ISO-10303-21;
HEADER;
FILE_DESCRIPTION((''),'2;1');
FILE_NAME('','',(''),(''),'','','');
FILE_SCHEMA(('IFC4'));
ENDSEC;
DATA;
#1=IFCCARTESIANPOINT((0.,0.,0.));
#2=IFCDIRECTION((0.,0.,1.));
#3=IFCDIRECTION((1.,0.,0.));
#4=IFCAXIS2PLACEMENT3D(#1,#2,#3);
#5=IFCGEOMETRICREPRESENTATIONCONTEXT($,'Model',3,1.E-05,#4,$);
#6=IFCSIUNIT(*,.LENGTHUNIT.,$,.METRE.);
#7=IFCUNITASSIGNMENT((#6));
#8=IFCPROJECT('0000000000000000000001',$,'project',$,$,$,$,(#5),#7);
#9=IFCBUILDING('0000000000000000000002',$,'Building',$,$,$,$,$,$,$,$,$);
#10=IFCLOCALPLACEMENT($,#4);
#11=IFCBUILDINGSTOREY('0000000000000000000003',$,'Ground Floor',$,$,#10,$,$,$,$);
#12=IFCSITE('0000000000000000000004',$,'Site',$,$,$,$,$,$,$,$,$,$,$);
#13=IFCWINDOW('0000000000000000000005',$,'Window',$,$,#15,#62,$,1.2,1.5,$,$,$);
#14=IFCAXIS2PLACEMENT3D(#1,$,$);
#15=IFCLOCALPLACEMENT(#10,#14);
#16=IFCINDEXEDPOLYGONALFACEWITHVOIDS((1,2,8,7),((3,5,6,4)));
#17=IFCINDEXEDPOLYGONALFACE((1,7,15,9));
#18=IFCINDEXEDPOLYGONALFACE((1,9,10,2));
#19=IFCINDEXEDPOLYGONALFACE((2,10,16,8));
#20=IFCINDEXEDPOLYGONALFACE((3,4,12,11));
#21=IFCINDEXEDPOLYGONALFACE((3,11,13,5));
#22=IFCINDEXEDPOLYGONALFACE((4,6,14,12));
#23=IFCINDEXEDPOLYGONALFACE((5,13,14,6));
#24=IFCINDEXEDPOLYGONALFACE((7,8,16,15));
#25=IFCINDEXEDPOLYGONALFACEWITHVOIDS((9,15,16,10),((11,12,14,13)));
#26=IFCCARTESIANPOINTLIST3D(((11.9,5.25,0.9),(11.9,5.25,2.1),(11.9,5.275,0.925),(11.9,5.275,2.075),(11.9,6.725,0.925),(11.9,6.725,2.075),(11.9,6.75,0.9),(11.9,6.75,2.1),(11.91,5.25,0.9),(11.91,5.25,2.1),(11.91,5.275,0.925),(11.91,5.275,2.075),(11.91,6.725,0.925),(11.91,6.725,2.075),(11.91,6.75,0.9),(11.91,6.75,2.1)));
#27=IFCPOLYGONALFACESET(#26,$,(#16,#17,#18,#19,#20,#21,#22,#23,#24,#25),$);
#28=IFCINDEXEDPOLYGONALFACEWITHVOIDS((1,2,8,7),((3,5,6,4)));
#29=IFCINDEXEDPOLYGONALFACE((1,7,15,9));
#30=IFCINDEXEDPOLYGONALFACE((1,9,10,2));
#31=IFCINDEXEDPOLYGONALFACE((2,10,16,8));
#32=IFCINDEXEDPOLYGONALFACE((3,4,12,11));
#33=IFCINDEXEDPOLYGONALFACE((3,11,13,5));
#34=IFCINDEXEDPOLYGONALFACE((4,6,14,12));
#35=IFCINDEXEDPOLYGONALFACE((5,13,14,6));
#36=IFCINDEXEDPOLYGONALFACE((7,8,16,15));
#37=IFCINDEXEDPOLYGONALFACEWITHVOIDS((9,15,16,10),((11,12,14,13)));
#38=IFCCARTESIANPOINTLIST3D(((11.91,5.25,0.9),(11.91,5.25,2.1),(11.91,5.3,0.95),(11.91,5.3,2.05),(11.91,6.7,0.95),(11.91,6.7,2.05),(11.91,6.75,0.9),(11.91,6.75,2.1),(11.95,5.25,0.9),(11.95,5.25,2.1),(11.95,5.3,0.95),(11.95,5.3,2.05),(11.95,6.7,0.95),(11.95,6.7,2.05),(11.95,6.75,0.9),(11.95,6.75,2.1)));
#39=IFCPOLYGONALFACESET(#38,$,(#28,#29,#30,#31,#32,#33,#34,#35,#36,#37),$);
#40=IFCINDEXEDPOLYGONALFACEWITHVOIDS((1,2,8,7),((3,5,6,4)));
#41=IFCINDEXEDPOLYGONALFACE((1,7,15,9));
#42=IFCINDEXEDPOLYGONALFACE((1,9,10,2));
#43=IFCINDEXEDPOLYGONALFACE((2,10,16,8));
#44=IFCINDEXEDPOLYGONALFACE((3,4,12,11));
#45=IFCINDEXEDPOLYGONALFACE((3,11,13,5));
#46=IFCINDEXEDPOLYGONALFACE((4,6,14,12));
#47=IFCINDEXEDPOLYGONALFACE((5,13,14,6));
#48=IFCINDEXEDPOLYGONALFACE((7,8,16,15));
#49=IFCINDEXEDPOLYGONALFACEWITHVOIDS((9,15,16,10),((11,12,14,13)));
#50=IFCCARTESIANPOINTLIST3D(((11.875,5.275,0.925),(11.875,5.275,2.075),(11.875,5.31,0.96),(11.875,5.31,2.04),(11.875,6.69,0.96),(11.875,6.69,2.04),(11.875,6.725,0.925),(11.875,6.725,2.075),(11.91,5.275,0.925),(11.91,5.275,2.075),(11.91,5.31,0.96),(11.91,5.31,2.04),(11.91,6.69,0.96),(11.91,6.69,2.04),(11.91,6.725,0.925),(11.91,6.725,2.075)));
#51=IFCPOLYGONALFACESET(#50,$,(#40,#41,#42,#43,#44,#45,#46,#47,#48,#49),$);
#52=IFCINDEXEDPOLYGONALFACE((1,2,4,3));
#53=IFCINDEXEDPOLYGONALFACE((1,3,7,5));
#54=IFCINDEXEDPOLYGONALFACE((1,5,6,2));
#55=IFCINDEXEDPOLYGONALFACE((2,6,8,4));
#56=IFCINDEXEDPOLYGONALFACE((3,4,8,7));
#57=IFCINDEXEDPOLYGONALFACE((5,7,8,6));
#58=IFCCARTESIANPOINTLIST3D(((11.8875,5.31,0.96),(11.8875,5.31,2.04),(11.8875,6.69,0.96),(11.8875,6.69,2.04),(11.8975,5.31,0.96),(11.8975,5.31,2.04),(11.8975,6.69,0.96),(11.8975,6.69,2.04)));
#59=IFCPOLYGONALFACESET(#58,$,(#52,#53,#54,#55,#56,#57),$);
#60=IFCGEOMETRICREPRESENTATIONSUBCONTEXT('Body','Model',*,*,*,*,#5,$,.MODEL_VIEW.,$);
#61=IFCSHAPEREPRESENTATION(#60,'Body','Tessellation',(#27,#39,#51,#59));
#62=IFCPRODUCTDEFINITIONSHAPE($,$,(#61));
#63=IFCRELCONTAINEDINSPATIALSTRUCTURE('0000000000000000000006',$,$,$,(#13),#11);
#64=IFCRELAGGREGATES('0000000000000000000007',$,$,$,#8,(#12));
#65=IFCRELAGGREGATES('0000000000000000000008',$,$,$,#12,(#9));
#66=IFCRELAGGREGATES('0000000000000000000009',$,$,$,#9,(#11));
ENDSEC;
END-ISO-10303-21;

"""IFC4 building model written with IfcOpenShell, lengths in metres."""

from ifc_helpers import new_model, si_unit, frame, origin_with_axes, place, context, subcontext, project, spatial, line, indexed_curve, outline, extrude, element, save


model = new_model("IFC4")

# Units and contexts
model_context = context("Model", 3, precision=1e-05, world=origin_with_axes())
body_context = subcontext(model_context, "Body", "Model", "MODEL_VIEW")
ifc_project = project(units=[si_unit("LENGTHUNIT", "METRE")], contexts=[model_context])

# Site, building, storey
site = spatial("IfcSite", under=ifc_project, Name="Site")
building = spatial("IfcBuilding", under=site, Name="Building")
storey_placement = place(None, origin_with_axes())
storey = spatial("IfcBuildingStorey", under=building, at=storey_placement, Name="Ground Floor")

# Window
for number, where, z_axis, x_axis, name in (
    (1, (12.0, 5.25, 0.9), (0.0, 0.0, 1.0), (0.0, 1.0, 0.0), "Window"),
):
    element("IfcWindow", number, at=place(storey_placement, frame(where, z_axis=z_axis, x_axis=x_axis)), inside=storey, Name=name, OverallHeight=1.2, OverallWidth=1.5, context=body_context, shape_type="SweptSolid", body=[
        extrude(outline(indexed_curve([(0.0, 0.0), (1.5, 0.0), (1.5, 1.2), (0.0, 1.2)], segments=[line(1, 2, 3, 4, 1)]), holes=[indexed_curve([(0.025, 0.025), (1.475, 0.025), (1.475, 1.175), (0.025, 1.175)], segments=[line(1, 2, 3, 4, 1)])]), frame((0.0, 0.09, 0.0), z_axis=(0.0, -1.0, 0.0), x_axis=(1.0, 0.0, 0.0)), (0.0, 0.0, -1.0), 0.01),
        extrude(outline(indexed_curve([(0.0, 0.0), (1.5, 0.0), (1.5, 1.2), (0.0, 1.2)], segments=[line(1, 2, 3, 4, 1)]), holes=[indexed_curve([(0.05, 0.05), (1.45, 0.05), (1.45, 1.15), (0.05, 1.15)], segments=[line(1, 2, 3, 4, 1)])]), frame((0.0, 0.05, 0.0), z_axis=(0.0, -1.0, 0.0), x_axis=(1.0, 0.0, 0.0)), (0.0, 0.0, -1.0), 0.04),
        extrude(outline(indexed_curve([(0.0, 0.0), (1.45, 0.0), (1.45, 1.15), (0.0, 1.15)], segments=[line(1, 2, 3, 4, 1)]), holes=[indexed_curve([(0.035, 0.035), (1.415, 0.035), (1.415, 1.115), (0.035, 1.115)], segments=[line(1, 2, 3, 4, 1)])]), frame((0.025, 0.09, 0.025), z_axis=(0.0, -1.0, 0.0), x_axis=(1.0, 0.0, 0.0)), (0.0, 0.0, -1.0), 0.035),
        extrude(outline(indexed_curve([(0.035, 0.035), (1.415, 0.035), (1.415, 1.115), (0.035, 1.115)], segments=[line(1, 2, 3, 4, 1)])), frame((0.025, 0.1025, 0.025), z_axis=(0.0, -1.0, 0.0), x_axis=(1.0, 0.0, 0.0)), (0.0, 0.0, -1.0), 0.01),
    ])

save(model, "model.ifc")
